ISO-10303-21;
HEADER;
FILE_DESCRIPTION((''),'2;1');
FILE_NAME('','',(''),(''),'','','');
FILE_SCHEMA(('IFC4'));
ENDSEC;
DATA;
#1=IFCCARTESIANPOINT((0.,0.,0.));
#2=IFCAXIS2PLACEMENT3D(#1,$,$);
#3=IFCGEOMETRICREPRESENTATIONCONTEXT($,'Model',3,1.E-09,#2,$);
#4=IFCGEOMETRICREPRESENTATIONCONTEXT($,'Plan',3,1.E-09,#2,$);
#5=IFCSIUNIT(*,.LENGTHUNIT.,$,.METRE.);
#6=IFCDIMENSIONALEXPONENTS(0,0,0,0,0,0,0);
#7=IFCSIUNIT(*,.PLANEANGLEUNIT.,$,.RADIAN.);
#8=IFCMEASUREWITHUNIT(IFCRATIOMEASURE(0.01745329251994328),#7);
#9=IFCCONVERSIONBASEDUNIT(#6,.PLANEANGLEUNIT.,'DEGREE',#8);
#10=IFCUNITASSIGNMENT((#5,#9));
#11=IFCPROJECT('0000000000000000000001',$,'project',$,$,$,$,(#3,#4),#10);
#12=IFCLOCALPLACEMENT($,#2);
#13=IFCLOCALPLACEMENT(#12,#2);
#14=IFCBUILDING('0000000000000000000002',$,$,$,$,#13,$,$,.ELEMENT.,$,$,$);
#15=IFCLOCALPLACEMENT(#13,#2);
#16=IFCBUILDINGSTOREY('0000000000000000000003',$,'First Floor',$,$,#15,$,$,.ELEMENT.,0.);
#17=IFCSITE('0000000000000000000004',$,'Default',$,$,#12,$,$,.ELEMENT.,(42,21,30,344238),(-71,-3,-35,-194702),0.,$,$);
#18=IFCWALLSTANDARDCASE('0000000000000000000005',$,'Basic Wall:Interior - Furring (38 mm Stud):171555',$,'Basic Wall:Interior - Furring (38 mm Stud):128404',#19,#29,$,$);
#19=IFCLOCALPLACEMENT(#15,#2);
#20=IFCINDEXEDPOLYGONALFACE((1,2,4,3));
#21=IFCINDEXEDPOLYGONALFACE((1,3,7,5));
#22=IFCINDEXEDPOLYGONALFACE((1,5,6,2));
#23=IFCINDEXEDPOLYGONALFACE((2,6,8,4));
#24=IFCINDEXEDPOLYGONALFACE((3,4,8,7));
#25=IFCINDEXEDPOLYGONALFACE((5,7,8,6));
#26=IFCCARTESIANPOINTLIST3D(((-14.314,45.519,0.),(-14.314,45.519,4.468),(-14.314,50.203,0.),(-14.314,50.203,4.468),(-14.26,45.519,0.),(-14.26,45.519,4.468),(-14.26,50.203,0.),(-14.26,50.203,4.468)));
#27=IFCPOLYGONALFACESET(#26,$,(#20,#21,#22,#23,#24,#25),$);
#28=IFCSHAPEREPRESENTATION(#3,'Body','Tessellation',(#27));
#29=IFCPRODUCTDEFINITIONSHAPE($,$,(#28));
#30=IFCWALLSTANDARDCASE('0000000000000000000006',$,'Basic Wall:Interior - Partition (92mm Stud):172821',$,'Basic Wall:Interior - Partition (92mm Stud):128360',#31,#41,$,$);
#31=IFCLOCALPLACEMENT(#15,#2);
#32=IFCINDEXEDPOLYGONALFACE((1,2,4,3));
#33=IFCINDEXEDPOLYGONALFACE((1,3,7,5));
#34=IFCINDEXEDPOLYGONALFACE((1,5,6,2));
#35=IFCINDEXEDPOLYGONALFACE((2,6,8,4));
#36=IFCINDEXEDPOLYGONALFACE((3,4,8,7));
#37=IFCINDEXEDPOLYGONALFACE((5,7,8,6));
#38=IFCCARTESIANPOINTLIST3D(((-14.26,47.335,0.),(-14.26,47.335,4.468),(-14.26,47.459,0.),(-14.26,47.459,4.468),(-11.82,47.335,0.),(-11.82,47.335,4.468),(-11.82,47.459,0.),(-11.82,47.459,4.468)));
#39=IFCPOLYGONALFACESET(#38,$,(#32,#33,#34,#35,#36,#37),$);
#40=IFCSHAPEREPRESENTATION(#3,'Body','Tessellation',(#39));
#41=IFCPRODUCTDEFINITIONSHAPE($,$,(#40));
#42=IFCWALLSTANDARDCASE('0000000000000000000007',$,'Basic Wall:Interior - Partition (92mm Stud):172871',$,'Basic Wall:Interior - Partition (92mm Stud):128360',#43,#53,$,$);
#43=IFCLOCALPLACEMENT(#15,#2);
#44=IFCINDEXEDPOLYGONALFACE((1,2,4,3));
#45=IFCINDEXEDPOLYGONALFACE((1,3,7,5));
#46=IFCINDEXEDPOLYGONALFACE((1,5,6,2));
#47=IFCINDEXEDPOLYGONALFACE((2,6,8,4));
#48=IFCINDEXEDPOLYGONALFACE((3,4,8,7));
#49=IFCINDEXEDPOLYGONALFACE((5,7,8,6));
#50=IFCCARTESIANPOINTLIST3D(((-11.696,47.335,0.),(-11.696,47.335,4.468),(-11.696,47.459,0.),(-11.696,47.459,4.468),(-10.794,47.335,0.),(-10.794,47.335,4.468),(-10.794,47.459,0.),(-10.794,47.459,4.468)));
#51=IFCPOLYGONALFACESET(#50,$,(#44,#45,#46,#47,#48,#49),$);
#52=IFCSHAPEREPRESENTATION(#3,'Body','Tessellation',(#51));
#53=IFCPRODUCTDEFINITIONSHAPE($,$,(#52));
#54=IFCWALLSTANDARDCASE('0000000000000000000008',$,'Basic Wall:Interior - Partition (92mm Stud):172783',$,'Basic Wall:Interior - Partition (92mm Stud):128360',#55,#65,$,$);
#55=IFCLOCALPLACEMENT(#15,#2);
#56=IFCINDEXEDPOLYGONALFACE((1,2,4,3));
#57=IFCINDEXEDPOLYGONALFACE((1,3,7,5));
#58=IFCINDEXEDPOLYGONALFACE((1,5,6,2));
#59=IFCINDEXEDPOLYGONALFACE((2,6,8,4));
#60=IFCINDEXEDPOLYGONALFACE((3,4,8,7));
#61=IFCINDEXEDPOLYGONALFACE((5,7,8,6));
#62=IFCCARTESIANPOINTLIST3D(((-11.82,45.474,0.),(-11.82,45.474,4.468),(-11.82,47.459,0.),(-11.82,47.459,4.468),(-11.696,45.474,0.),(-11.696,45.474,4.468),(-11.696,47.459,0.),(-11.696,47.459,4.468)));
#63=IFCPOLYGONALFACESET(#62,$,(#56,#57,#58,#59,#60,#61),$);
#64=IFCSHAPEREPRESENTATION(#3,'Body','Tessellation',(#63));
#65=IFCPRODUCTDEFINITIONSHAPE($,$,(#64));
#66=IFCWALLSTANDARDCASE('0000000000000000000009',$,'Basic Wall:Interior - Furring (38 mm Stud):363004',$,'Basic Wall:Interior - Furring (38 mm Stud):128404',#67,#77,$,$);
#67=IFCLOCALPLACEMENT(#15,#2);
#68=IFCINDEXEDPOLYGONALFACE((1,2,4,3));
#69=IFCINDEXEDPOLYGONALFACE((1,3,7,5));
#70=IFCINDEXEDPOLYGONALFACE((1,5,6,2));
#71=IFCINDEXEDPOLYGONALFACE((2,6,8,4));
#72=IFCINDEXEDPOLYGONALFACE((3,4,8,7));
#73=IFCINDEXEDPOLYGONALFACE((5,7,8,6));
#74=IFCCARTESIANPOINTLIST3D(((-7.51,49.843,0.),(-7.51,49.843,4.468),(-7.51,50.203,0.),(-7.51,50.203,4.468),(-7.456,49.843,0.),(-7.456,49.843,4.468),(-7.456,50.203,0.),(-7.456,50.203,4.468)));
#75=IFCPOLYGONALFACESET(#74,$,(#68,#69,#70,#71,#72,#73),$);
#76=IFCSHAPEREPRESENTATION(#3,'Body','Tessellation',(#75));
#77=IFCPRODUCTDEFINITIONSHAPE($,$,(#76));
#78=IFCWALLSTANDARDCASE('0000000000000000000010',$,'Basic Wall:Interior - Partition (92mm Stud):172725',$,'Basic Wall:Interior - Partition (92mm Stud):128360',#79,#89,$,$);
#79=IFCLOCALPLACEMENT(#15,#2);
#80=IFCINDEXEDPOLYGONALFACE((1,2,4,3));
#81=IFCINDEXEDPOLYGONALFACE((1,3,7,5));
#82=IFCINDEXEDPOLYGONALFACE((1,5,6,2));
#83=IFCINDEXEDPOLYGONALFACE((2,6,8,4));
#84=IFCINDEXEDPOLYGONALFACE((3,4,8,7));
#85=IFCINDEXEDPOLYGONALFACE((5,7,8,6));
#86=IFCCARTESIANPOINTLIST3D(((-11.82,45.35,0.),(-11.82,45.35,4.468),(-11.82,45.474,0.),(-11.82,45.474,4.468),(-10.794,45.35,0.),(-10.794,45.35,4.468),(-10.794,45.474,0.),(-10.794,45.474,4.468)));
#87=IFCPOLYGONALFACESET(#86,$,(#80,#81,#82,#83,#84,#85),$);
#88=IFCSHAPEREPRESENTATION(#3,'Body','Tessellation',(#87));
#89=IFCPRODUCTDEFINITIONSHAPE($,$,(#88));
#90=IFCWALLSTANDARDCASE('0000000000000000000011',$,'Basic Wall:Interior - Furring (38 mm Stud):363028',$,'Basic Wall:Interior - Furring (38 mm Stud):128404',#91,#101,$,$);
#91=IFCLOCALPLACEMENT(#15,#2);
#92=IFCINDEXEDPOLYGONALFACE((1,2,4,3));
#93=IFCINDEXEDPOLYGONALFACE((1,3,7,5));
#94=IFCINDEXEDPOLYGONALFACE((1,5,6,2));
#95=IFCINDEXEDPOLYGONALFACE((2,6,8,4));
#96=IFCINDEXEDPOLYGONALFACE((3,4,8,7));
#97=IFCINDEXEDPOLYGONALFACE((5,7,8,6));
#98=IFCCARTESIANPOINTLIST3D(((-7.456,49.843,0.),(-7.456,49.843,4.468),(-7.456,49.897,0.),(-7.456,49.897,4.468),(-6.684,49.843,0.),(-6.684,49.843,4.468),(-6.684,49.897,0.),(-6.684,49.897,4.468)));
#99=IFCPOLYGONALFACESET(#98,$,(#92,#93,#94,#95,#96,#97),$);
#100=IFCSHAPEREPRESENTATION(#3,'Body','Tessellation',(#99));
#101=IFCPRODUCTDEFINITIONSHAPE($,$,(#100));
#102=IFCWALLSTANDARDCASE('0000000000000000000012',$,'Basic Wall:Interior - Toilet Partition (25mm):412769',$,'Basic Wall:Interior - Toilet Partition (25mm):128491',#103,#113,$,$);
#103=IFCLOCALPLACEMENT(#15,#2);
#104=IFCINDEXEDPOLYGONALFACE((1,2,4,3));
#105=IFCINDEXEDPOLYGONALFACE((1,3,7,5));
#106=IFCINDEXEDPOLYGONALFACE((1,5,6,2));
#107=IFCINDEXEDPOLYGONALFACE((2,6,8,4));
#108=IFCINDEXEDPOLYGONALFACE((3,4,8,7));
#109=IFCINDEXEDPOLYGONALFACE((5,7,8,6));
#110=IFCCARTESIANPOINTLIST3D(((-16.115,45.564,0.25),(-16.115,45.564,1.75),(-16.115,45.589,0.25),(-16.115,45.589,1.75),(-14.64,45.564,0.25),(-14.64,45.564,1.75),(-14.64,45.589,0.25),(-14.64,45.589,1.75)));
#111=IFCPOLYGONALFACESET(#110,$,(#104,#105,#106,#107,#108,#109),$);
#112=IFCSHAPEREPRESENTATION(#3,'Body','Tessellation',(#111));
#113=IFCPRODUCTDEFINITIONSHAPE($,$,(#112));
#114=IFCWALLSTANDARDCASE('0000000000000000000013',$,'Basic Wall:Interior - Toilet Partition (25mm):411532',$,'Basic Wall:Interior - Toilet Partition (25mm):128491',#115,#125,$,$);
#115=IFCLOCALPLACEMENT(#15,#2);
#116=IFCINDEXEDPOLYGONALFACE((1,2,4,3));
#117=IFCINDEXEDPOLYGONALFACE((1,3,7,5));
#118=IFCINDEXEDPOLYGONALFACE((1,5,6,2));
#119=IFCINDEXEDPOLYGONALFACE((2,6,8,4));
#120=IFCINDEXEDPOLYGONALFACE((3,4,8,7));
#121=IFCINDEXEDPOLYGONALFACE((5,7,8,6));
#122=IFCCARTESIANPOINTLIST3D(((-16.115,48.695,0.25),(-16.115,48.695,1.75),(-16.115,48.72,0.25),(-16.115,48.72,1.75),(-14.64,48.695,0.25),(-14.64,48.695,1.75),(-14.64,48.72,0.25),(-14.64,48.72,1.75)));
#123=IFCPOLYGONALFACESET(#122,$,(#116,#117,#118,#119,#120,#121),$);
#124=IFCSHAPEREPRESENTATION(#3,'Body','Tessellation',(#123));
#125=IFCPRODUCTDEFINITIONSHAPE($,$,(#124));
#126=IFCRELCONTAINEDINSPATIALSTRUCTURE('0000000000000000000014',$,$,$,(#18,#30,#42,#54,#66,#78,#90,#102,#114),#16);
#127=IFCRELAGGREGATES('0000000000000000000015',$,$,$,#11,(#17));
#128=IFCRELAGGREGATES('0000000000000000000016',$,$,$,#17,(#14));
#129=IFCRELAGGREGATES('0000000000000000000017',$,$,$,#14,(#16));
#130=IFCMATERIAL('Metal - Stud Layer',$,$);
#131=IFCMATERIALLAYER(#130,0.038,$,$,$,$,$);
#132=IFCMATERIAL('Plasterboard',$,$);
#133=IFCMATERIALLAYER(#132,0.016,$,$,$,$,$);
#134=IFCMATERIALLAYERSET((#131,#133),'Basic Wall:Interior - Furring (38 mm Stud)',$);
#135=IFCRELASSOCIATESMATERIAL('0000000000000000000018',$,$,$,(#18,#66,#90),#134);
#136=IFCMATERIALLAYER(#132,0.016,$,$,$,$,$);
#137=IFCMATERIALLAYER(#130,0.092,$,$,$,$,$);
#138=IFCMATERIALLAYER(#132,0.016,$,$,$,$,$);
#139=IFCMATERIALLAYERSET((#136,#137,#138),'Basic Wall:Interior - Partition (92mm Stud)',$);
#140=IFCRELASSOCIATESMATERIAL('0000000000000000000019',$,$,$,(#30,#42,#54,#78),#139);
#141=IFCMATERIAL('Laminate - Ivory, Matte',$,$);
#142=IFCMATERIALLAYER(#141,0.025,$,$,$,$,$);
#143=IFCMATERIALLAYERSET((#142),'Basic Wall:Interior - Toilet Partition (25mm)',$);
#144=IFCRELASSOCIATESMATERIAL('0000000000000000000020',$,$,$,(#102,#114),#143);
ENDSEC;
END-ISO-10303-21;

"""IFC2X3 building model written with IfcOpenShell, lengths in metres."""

from ifc_helpers import new_model, entity, si_unit, converted_unit, frame, frame_2d, origin, place, context, project, spatial, rectangle, extrude, material, layer, layer_set, layer_usage, element, save


model = new_model("IFC2X3")

# Units and contexts
model_context = context("Model", 3, precision=1e-09, world=origin())
plan_context = context("Plan", 3, precision=1e-09, world=origin())
ifc_project = project(units=[si_unit("LENGTHUNIT", "METRE"), converted_unit("PLANEANGLEUNIT", "DEGREE", entity("IfcRatioMeasure", 0.01745329251994328), si_unit("PLANEANGLEUNIT", "RADIAN"), dimensions=[0, 0, 0, 0, 0, 0, 0])], contexts=[model_context, plan_context])

# Site, building, storey
site_placement = place(None, origin())
site = spatial("IfcSite", under=ifc_project, at=site_placement, Name="Default", CompositionType="ELEMENT", RefLatitude=(42, 21, 30, 344238), RefLongitude=(-71, -3, -35, -194702), RefElevation=0.0)
building_placement = place(site_placement, origin())
building = spatial("IfcBuilding", under=site, at=building_placement, CompositionType="ELEMENT")
storey_placement = place(building_placement, origin())
storey = spatial("IfcBuildingStorey", under=building, at=storey_placement, Name="First Floor", CompositionType="ELEMENT", Elevation=0.0)

# Shared definitions
ifc_material_1 = material(Name="Plasterboard")
ifc_layer_1 = layer(ifc_material_1, 0.016)
ifc_material_2 = material(Name="Metal - Stud Layer")
ifc_layer_2 = layer(ifc_material_2, 0.092)
ifc_layer_3 = layer(ifc_material_1, 0.016)
ifc_layer_set_1 = layer_set([ifc_layer_1, ifc_layer_2, ifc_layer_3], Name="Basic Wall:Interior - Partition (92mm Stud)")
ifc_layer_usage_1 = layer_usage(ifc_layer_set_1, "AXIS2", "NEGATIVE", 0.062)

# Walls
ifc_layer_4 = layer(ifc_material_2, 0.038)
ifc_layer_5 = layer(ifc_material_1, 0.016)
ifc_layer_set_2 = layer_set([ifc_layer_4, ifc_layer_5], Name="Basic Wall:Interior - Furring (38 mm Stud)")
ifc_layer_usage_2 = layer_usage(ifc_layer_set_2, "AXIS2", "POSITIVE", -0.027)
ifc_layer_usage_3 = layer_usage(ifc_layer_set_2, "AXIS2", "NEGATIVE", 0.027)
wall_1_placement = place(storey_placement, frame((-14.287, 50.203, 0.0), z_axis=(0.0, 0.0, 1.0), x_axis=(0.0, -1.0, 0.0)))
element("IfcWallStandardCase", 1, at=wall_1_placement, inside=storey, material=ifc_layer_usage_2, Name="Basic Wall:Interior - Furring (38 mm Stud):171555", ObjectType="Basic Wall:Interior - Furring (38 mm Stud):128404", context=model_context, shape_type="SweptSolid", body=[
    extrude(rectangle(XDim=4.684, YDim=0.054, at=frame_2d((2.342, 0.0), x_axis=(-1.0, 0.0))), origin(), (0.0, 0.0, 1.0), 4.468),
])
wall_2_placement = place(storey_placement, frame((-11.82, 47.397, 0.0), z_axis=(0.0, 0.0, 1.0), x_axis=(-1.0, 0.0, 0.0)))
element("IfcWallStandardCase", 2, at=wall_2_placement, inside=storey, material=ifc_layer_usage_1, Name="Basic Wall:Interior - Partition (92mm Stud):172821", ObjectType="Basic Wall:Interior - Partition (92mm Stud):128360", context=model_context, shape_type="SweptSolid", body=[
    extrude(rectangle(XDim=2.44, YDim=0.124, at=frame_2d((1.22, 0.0), x_axis=(-1.0, 0.0))), origin(), (0.0, 0.0, 1.0), 4.468),
])
wall_3_placement = place(storey_placement, frame((-11.696, 47.397, 0.0)))
element("IfcWallStandardCase", 3, at=wall_3_placement, inside=storey, material=ifc_layer_usage_1, Name="Basic Wall:Interior - Partition (92mm Stud):172871", ObjectType="Basic Wall:Interior - Partition (92mm Stud):128360", context=model_context, shape_type="SweptSolid", body=[
    extrude(rectangle(XDim=0.902, YDim=0.124, at=frame_2d((0.451, 0.0), x_axis=(-1.0, 0.0))), origin(), (0.0, 0.0, 1.0), 4.468),
])
wall_4_placement = place(storey_placement, frame((-11.758, 45.474, 0.0), z_axis=(0.0, 0.0, 1.0), x_axis=(0.0, 1.0, 0.0)))
element("IfcWallStandardCase", 4, at=wall_4_placement, inside=storey, material=ifc_layer_usage_1, Name="Basic Wall:Interior - Partition (92mm Stud):172783", ObjectType="Basic Wall:Interior - Partition (92mm Stud):128360", context=model_context, shape_type="SweptSolid", body=[
    extrude(rectangle(XDim=1.985, YDim=0.124, at=frame_2d((0.9925, 0.0), x_axis=(-1.0, 0.0))), origin(), (0.0, 0.0, 1.0), 4.468),
])
wall_5_placement = place(storey_placement, frame((-7.483, 50.203, 0.0), z_axis=(0.0, 0.0, 1.0), x_axis=(0.0, -1.0, 0.0)))
element("IfcWallStandardCase", 5, at=wall_5_placement, inside=storey, material=ifc_layer_usage_3, Name="Basic Wall:Interior - Furring (38 mm Stud):363004", ObjectType="Basic Wall:Interior - Furring (38 mm Stud):128404", context=model_context, shape_type="SweptSolid", body=[
    extrude(rectangle(XDim=0.36, YDim=0.054, at=frame_2d((0.18, 0.0), x_axis=(-1.0, 0.0))), origin(), (0.0, 0.0, 1.0), 4.468),
])
wall_6_placement = place(storey_placement, frame((-10.794, 45.412, 0.0), z_axis=(0.0, 0.0, 1.0), x_axis=(-1.0, 0.0, 0.0)))
element("IfcWallStandardCase", 6, at=wall_6_placement, inside=storey, material=ifc_layer_usage_1, Name="Basic Wall:Interior - Partition (92mm Stud):172725", ObjectType="Basic Wall:Interior - Partition (92mm Stud):128360", context=model_context, shape_type="SweptSolid", body=[
    extrude(rectangle(XDim=1.026, YDim=0.124, at=frame_2d((0.513, 0.0), x_axis=(-1.0, 0.0))), origin(), (0.0, 0.0, 1.0), 4.468),
])
wall_7_placement = place(storey_placement, frame((-7.456, 49.87, 0.0)))
element("IfcWallStandardCase", 7, at=wall_7_placement, inside=storey, material=ifc_layer_usage_3, Name="Basic Wall:Interior - Furring (38 mm Stud):363028", ObjectType="Basic Wall:Interior - Furring (38 mm Stud):128404", context=model_context, shape_type="SweptSolid", body=[
    extrude(rectangle(XDim=0.772, YDim=0.054, at=frame_2d((0.386, 0.0), x_axis=(-1.0, 0.0))), origin(), (0.0, 0.0, 1.0), 4.468),
])
ifc_material_3 = material(Name="Laminate - Ivory, Matte")
ifc_layer_6 = layer(ifc_material_3, 0.025)
ifc_layer_set_3 = layer_set([ifc_layer_6], Name="Basic Wall:Interior - Toilet Partition (25mm)")
ifc_layer_usage_4 = layer_usage(ifc_layer_set_3, "AXIS2", "NEGATIVE", 0.0125)
wall_8_placement = place(storey_placement, frame((-14.64, 45.5765, 0.25), z_axis=(0.0, 0.0, 1.0), x_axis=(-1.0, 0.0, 0.0)))
element("IfcWallStandardCase", 8, at=wall_8_placement, inside=storey, material=ifc_layer_usage_4, Name="Basic Wall:Interior - Toilet Partition (25mm):412769", ObjectType="Basic Wall:Interior - Toilet Partition (25mm):128491", context=model_context, shape_type="SweptSolid", body=[
    extrude(rectangle(XDim=1.475, YDim=0.025, at=frame_2d((0.7375, 0.0), x_axis=(-1.0, 0.0))), origin(), (0.0, 0.0, 1.0), 1.5),
])
ifc_layer_usage_5 = layer_usage(ifc_layer_set_3, "AXIS2", "POSITIVE", -0.0125)
wall_9_placement = place(storey_placement, frame((-14.64, 48.7075, 0.25), z_axis=(0.0, 0.0, 1.0), x_axis=(-1.0, 0.0, 0.0)))
element("IfcWallStandardCase", 9, at=wall_9_placement, inside=storey, material=ifc_layer_usage_5, Name="Basic Wall:Interior - Toilet Partition (25mm):411532", ObjectType="Basic Wall:Interior - Toilet Partition (25mm):128491", context=model_context, shape_type="SweptSolid", body=[
    extrude(rectangle(XDim=1.475, YDim=0.025, at=frame_2d((0.7375, 0.0), x_axis=(-1.0, 0.0))), origin(), (0.0, 0.0, 1.0), 1.5),
])

save(model, "model.ifc")
